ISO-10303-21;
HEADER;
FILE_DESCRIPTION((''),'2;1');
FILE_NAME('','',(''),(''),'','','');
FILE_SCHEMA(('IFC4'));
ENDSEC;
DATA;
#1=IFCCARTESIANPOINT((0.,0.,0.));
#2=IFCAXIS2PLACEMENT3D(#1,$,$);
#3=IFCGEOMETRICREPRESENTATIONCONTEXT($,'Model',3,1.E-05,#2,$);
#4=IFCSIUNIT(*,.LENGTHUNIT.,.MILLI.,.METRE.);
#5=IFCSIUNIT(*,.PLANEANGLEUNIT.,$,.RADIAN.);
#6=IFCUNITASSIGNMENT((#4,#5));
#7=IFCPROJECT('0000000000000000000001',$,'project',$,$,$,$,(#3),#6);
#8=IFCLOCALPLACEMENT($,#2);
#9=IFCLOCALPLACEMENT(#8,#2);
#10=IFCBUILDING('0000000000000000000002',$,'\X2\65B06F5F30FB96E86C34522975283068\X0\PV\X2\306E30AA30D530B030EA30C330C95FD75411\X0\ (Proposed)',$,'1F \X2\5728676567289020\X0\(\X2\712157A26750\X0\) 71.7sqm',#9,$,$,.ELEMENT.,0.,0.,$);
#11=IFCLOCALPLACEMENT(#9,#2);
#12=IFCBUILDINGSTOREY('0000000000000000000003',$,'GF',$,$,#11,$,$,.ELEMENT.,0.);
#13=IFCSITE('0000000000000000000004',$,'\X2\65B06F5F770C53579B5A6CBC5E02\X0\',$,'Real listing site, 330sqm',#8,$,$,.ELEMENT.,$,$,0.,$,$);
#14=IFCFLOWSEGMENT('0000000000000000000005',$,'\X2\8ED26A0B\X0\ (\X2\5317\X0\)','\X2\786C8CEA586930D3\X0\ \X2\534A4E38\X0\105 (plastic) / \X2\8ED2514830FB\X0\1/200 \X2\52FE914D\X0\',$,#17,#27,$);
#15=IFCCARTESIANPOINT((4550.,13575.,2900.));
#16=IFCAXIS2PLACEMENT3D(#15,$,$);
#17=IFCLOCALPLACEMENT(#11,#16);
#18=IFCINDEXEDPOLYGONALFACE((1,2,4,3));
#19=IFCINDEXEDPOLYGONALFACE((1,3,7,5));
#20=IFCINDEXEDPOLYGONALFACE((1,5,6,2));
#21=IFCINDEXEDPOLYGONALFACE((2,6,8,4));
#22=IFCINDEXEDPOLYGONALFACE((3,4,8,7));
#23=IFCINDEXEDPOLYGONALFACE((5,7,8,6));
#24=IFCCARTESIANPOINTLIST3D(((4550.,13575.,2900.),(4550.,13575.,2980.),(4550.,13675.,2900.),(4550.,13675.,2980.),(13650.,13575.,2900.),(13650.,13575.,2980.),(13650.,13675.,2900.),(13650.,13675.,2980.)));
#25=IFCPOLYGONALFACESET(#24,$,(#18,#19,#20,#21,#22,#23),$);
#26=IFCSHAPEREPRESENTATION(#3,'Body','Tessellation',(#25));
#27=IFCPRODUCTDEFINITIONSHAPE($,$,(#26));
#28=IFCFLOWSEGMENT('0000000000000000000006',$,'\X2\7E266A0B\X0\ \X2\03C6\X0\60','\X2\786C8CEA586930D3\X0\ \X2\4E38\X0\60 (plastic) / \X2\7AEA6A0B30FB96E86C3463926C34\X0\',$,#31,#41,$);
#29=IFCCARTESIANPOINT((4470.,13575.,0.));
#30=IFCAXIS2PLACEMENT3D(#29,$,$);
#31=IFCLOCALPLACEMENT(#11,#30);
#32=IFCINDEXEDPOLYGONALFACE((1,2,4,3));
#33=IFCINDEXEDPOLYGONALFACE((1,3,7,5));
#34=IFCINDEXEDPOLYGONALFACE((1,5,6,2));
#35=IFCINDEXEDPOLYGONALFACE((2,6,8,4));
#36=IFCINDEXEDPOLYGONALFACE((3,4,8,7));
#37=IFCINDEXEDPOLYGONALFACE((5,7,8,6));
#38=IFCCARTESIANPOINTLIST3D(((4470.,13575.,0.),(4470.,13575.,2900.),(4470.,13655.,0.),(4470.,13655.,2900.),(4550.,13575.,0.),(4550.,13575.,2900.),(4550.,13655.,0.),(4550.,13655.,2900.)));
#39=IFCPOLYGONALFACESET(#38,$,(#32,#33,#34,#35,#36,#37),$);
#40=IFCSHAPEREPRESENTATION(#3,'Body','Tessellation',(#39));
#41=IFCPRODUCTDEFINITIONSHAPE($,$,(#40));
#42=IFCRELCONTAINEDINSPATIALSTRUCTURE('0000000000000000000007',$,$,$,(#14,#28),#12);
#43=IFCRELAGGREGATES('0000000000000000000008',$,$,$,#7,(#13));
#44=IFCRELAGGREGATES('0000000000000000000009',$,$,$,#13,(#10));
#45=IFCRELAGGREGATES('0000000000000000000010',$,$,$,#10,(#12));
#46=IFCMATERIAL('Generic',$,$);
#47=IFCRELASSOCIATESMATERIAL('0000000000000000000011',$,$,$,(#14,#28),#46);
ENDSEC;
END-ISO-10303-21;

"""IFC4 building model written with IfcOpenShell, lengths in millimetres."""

from ifc_helpers import new_model, si_unit, frame, frame_2d, origin, place, context, project, spatial, rectangle, extrude, material, element, save


model = new_model("IFC4")

# Units and contexts
model_context = context("Model", 3, precision=1e-05, world=origin())
ifc_project = project(units=[si_unit("LENGTHUNIT", "METRE", prefix="MILLI"), si_unit("PLANEANGLEUNIT", "RADIAN")], contexts=[model_context])

# Site, building, storey
site_placement = place(None, origin())
site = spatial("IfcSite", under=ifc_project, at=site_placement, Name="新潟県南魚沼市", ObjectType="Real listing site, 330sqm", CompositionType="ELEMENT", RefElevation=0.0)
building_placement = place(site_placement, origin())
building = spatial("IfcBuilding", under=site, at=building_placement, Name="新潟・雨水利用とPVのオフグリッド志向 (Proposed)", ObjectType="1F 在来木造(無垢材) 71.7sqm", CompositionType="ELEMENT", ElevationOfRefHeight=0.0, ElevationOfTerrain=0.0)
storey_placement = place(building_placement, origin())
storey = spatial("IfcBuildingStorey", under=building, at=storey_placement, Name="GF", CompositionType="ELEMENT", Elevation=0.0)

# Shared definitions
ifc_material_1 = material(Name="Generic")

# Flow segments
flow_segment_1_placement = place(storey_placement, frame((4550.0, 13575.0, 2900.0)))
element("IfcFlowSegment", 1, at=flow_segment_1_placement, inside=storey, material=ifc_material_1, Name="軒樋 (北)", Description="硬質塩ビ 半丸105 (plastic) / 軒先・1/200 勾配", context=model_context, shape_type="SweptSolid", body=[
    extrude(rectangle(XDim=9100.0, YDim=100.0, at=frame_2d((4550.0, 50.0))), frame((4550.0, 13575.0, 2900.0)), (0.0, 0.0, 1.0), 80.0),
])
flow_segment_2_placement = place(storey_placement, frame((4470.0, 13575.0, 0.0)))
element("IfcFlowSegment", 2, at=flow_segment_2_placement, inside=storey, material=ifc_material_1, Name="縦樋 φ60", Description="硬質塩ビ 丸60 (plastic) / 竪樋・雨水排水", context=model_context, shape_type="SweptSolid", body=[
    extrude(rectangle(XDim=80.0, YDim=80.0, at=frame_2d((40.0, 40.0))), frame((4470.0, 13575.0, 0.0)), (0.0, 0.0, 1.0), 2900.0),
])

save(model, "model.ifc")
